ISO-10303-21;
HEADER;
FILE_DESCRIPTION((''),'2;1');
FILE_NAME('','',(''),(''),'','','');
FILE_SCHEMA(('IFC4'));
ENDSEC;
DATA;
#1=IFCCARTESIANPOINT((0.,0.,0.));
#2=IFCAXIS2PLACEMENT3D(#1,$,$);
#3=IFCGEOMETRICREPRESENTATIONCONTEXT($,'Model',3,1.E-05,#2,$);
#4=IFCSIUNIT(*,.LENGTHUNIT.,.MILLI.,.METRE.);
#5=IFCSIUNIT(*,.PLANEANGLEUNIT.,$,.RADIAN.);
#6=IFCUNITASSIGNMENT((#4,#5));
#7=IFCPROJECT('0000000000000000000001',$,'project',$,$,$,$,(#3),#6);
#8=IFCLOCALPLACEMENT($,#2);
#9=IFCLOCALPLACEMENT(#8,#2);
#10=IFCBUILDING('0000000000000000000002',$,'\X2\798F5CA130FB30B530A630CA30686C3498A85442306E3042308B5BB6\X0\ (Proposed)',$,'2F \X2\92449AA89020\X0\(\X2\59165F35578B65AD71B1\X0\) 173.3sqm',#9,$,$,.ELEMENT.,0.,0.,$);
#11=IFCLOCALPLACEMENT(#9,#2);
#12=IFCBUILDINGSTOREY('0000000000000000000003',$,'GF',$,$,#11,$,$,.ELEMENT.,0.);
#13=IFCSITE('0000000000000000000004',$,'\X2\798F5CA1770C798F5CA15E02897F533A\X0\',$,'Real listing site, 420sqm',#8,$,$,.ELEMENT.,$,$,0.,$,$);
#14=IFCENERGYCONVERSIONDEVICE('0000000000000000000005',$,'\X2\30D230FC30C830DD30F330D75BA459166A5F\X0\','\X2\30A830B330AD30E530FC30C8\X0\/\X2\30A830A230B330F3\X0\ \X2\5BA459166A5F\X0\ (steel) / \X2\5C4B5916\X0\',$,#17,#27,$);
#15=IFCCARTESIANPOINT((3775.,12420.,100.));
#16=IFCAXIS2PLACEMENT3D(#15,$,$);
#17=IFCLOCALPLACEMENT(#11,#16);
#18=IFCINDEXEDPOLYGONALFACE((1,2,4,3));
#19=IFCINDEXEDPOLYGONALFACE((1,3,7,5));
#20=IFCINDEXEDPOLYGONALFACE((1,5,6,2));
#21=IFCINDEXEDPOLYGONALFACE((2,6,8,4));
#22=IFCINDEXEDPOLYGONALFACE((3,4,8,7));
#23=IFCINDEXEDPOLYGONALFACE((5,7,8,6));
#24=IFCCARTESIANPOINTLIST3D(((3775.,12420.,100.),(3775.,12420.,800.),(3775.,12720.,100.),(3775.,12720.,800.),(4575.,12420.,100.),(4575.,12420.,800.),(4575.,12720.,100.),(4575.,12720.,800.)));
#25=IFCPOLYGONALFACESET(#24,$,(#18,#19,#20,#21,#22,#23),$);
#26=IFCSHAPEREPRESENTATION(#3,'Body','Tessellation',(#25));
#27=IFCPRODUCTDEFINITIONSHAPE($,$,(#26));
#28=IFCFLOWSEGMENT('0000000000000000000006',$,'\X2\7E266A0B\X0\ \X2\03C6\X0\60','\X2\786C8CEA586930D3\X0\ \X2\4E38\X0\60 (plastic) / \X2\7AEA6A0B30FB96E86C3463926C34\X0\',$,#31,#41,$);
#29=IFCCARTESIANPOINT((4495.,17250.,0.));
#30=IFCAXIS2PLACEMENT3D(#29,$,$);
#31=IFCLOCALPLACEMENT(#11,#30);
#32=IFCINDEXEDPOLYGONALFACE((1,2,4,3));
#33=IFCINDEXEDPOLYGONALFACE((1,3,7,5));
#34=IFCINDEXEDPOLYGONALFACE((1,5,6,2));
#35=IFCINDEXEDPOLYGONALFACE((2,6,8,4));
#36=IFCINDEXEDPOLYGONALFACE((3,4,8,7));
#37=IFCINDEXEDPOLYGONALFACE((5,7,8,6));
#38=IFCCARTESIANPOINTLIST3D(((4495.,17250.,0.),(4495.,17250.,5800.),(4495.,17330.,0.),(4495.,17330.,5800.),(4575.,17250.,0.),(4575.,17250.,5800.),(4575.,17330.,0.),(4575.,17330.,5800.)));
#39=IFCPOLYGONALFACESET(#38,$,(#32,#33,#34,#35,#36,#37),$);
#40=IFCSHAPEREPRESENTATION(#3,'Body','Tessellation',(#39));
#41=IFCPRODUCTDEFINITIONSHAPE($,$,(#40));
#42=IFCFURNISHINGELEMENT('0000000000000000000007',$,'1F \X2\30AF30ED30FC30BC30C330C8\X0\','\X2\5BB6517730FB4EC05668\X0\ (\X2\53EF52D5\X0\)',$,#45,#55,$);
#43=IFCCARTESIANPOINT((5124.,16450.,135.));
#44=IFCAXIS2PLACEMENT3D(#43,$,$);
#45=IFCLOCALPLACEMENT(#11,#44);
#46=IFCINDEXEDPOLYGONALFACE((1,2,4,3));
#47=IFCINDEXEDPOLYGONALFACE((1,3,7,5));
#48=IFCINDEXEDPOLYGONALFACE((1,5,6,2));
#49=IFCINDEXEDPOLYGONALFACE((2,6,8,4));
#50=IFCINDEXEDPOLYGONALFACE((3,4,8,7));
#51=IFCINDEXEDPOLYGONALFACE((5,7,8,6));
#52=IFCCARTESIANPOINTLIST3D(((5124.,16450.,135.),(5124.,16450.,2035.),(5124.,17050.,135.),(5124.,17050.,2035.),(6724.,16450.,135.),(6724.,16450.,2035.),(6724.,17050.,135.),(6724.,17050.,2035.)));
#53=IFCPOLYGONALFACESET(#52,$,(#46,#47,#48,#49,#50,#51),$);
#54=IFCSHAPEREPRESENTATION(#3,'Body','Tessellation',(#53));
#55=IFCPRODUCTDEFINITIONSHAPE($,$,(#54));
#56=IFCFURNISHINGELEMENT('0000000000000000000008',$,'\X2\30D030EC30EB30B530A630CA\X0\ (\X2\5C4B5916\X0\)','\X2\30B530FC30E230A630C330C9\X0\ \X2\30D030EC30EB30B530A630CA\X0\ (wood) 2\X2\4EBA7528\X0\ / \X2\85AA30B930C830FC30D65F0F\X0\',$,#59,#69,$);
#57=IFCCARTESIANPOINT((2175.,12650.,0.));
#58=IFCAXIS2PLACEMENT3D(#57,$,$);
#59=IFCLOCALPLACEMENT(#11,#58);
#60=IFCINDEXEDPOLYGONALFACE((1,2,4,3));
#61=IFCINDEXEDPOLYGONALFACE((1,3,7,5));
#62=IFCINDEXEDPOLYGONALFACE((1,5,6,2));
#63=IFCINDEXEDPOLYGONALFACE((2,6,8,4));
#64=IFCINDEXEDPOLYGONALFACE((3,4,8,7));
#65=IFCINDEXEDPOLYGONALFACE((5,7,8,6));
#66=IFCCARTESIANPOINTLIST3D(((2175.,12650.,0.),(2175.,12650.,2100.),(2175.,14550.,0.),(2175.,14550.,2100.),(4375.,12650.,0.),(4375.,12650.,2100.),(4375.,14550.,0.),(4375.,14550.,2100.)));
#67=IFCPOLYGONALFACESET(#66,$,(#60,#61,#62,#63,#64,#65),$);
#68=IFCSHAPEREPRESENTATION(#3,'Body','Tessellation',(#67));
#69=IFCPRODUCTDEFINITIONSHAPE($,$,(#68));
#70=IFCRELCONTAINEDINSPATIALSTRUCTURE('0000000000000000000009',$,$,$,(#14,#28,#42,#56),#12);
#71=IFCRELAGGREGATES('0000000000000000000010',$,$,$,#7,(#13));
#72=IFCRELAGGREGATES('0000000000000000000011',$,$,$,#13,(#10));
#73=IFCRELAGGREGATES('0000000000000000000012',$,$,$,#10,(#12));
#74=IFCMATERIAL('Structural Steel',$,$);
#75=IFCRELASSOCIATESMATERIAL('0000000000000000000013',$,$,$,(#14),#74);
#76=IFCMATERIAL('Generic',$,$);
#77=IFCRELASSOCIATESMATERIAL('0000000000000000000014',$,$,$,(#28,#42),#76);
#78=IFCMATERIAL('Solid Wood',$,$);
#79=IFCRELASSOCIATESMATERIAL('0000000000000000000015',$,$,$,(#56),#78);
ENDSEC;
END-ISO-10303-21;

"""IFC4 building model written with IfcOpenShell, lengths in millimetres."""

from ifc_helpers import new_model, si_unit, frame, frame_2d, origin, place, context, project, spatial, rectangle, extrude, material, element, save


model = new_model("IFC4")

# Units and contexts
model_context = context("Model", 3, precision=1e-05, world=origin())
ifc_project = project(units=[si_unit("LENGTHUNIT", "METRE", prefix="MILLI"), si_unit("PLANEANGLEUNIT", "RADIAN")], contexts=[model_context])

# Site, building, storey
site_placement = place(None, origin())
site = spatial("IfcSite", under=ifc_project, at=site_placement, Name="福岡県福岡市西区", ObjectType="Real listing site, 420sqm", CompositionType="ELEMENT", RefElevation=0.0)
building_placement = place(site_placement, origin())
building = spatial("IfcBuilding", under=site, at=building_placement, Name="福岡・サウナと水風呂のある家 (Proposed)", ObjectType="2F 鉄骨造(外張型断熱) 173.3sqm", CompositionType="ELEMENT", ElevationOfRefHeight=0.0, ElevationOfTerrain=0.0)
storey_placement = place(building_placement, origin())
storey = spatial("IfcBuildingStorey", under=building, at=storey_placement, Name="GF", CompositionType="ELEMENT", Elevation=0.0)

# Shared definitions
ifc_material_1 = material(Name="Solid Wood")

# Shared definitions
ifc_material_2 = material(Name="Generic")

# Energy conversion device
ifc_material_3 = material(Name="Structural Steel")
energy_conversion_device_placement = place(storey_placement, frame((3775.0, 12420.0, 100.0)))
element("IfcEnergyConversionDevice", 1, at=energy_conversion_device_placement, inside=storey, material=ifc_material_3, Name="ヒートポンプ室外機", Description="エコキュート/エアコン 室外機 (steel) / 屋外", context=model_context, shape_type="SweptSolid", body=[
    extrude(rectangle(XDim=800.0, YDim=300.0, at=frame_2d((400.0, 150.0))), frame((3775.0, 12420.0, 100.0)), (0.0, 0.0, 1.0), 700.0),
])

# Flow segment
flow_segment_placement = place(storey_placement, frame((4495.0, 17250.0, 0.0)))
element("IfcFlowSegment", 2, at=flow_segment_placement, inside=storey, material=ifc_material_2, Name="縦樋 φ60", Description="硬質塩ビ 丸60 (plastic) / 竪樋・雨水排水", context=model_context, shape_type="SweptSolid", body=[
    extrude(rectangle(XDim=80.0, YDim=80.0, at=frame_2d((40.0, 40.0))), frame((4495.0, 17250.0, 0.0)), (0.0, 0.0, 1.0), 5800.0),
])

# Furnishing elements
furnishing_1_placement = place(storey_placement, frame((5124.0, 16450.0, 135.0)))
element("IfcFurnishingElement", 3, at=furnishing_1_placement, inside=storey, material=ifc_material_2, Name="1F クローゼット", Description="家具・什器 (可動)", context=model_context, shape_type="SweptSolid", body=[
    extrude(rectangle(XDim=1600.0, YDim=600.0, at=frame_2d((800.0, 300.0))), frame((5124.0, 16450.0, 135.0)), (0.0, 0.0, 1.0), 1900.0),
])
furnishing_2_placement = place(storey_placement, frame((2175.0, 12650.0, 0.0)))
element("IfcFurnishingElement", 4, at=furnishing_2_placement, inside=storey, material=ifc_material_1, Name="バレルサウナ (屋外)", Description="サーモウッド バレルサウナ (wood) 2人用 / 薪ストーブ式", context=model_context, shape_type="SweptSolid", body=[
    extrude(rectangle(XDim=2200.0, YDim=1900.0, at=frame_2d((1100.0, 950.0))), frame((2175.0, 12650.0, 0.0)), (0.0, 0.0, 1.0), 2100.0),
])

save(model, "model.ifc")
